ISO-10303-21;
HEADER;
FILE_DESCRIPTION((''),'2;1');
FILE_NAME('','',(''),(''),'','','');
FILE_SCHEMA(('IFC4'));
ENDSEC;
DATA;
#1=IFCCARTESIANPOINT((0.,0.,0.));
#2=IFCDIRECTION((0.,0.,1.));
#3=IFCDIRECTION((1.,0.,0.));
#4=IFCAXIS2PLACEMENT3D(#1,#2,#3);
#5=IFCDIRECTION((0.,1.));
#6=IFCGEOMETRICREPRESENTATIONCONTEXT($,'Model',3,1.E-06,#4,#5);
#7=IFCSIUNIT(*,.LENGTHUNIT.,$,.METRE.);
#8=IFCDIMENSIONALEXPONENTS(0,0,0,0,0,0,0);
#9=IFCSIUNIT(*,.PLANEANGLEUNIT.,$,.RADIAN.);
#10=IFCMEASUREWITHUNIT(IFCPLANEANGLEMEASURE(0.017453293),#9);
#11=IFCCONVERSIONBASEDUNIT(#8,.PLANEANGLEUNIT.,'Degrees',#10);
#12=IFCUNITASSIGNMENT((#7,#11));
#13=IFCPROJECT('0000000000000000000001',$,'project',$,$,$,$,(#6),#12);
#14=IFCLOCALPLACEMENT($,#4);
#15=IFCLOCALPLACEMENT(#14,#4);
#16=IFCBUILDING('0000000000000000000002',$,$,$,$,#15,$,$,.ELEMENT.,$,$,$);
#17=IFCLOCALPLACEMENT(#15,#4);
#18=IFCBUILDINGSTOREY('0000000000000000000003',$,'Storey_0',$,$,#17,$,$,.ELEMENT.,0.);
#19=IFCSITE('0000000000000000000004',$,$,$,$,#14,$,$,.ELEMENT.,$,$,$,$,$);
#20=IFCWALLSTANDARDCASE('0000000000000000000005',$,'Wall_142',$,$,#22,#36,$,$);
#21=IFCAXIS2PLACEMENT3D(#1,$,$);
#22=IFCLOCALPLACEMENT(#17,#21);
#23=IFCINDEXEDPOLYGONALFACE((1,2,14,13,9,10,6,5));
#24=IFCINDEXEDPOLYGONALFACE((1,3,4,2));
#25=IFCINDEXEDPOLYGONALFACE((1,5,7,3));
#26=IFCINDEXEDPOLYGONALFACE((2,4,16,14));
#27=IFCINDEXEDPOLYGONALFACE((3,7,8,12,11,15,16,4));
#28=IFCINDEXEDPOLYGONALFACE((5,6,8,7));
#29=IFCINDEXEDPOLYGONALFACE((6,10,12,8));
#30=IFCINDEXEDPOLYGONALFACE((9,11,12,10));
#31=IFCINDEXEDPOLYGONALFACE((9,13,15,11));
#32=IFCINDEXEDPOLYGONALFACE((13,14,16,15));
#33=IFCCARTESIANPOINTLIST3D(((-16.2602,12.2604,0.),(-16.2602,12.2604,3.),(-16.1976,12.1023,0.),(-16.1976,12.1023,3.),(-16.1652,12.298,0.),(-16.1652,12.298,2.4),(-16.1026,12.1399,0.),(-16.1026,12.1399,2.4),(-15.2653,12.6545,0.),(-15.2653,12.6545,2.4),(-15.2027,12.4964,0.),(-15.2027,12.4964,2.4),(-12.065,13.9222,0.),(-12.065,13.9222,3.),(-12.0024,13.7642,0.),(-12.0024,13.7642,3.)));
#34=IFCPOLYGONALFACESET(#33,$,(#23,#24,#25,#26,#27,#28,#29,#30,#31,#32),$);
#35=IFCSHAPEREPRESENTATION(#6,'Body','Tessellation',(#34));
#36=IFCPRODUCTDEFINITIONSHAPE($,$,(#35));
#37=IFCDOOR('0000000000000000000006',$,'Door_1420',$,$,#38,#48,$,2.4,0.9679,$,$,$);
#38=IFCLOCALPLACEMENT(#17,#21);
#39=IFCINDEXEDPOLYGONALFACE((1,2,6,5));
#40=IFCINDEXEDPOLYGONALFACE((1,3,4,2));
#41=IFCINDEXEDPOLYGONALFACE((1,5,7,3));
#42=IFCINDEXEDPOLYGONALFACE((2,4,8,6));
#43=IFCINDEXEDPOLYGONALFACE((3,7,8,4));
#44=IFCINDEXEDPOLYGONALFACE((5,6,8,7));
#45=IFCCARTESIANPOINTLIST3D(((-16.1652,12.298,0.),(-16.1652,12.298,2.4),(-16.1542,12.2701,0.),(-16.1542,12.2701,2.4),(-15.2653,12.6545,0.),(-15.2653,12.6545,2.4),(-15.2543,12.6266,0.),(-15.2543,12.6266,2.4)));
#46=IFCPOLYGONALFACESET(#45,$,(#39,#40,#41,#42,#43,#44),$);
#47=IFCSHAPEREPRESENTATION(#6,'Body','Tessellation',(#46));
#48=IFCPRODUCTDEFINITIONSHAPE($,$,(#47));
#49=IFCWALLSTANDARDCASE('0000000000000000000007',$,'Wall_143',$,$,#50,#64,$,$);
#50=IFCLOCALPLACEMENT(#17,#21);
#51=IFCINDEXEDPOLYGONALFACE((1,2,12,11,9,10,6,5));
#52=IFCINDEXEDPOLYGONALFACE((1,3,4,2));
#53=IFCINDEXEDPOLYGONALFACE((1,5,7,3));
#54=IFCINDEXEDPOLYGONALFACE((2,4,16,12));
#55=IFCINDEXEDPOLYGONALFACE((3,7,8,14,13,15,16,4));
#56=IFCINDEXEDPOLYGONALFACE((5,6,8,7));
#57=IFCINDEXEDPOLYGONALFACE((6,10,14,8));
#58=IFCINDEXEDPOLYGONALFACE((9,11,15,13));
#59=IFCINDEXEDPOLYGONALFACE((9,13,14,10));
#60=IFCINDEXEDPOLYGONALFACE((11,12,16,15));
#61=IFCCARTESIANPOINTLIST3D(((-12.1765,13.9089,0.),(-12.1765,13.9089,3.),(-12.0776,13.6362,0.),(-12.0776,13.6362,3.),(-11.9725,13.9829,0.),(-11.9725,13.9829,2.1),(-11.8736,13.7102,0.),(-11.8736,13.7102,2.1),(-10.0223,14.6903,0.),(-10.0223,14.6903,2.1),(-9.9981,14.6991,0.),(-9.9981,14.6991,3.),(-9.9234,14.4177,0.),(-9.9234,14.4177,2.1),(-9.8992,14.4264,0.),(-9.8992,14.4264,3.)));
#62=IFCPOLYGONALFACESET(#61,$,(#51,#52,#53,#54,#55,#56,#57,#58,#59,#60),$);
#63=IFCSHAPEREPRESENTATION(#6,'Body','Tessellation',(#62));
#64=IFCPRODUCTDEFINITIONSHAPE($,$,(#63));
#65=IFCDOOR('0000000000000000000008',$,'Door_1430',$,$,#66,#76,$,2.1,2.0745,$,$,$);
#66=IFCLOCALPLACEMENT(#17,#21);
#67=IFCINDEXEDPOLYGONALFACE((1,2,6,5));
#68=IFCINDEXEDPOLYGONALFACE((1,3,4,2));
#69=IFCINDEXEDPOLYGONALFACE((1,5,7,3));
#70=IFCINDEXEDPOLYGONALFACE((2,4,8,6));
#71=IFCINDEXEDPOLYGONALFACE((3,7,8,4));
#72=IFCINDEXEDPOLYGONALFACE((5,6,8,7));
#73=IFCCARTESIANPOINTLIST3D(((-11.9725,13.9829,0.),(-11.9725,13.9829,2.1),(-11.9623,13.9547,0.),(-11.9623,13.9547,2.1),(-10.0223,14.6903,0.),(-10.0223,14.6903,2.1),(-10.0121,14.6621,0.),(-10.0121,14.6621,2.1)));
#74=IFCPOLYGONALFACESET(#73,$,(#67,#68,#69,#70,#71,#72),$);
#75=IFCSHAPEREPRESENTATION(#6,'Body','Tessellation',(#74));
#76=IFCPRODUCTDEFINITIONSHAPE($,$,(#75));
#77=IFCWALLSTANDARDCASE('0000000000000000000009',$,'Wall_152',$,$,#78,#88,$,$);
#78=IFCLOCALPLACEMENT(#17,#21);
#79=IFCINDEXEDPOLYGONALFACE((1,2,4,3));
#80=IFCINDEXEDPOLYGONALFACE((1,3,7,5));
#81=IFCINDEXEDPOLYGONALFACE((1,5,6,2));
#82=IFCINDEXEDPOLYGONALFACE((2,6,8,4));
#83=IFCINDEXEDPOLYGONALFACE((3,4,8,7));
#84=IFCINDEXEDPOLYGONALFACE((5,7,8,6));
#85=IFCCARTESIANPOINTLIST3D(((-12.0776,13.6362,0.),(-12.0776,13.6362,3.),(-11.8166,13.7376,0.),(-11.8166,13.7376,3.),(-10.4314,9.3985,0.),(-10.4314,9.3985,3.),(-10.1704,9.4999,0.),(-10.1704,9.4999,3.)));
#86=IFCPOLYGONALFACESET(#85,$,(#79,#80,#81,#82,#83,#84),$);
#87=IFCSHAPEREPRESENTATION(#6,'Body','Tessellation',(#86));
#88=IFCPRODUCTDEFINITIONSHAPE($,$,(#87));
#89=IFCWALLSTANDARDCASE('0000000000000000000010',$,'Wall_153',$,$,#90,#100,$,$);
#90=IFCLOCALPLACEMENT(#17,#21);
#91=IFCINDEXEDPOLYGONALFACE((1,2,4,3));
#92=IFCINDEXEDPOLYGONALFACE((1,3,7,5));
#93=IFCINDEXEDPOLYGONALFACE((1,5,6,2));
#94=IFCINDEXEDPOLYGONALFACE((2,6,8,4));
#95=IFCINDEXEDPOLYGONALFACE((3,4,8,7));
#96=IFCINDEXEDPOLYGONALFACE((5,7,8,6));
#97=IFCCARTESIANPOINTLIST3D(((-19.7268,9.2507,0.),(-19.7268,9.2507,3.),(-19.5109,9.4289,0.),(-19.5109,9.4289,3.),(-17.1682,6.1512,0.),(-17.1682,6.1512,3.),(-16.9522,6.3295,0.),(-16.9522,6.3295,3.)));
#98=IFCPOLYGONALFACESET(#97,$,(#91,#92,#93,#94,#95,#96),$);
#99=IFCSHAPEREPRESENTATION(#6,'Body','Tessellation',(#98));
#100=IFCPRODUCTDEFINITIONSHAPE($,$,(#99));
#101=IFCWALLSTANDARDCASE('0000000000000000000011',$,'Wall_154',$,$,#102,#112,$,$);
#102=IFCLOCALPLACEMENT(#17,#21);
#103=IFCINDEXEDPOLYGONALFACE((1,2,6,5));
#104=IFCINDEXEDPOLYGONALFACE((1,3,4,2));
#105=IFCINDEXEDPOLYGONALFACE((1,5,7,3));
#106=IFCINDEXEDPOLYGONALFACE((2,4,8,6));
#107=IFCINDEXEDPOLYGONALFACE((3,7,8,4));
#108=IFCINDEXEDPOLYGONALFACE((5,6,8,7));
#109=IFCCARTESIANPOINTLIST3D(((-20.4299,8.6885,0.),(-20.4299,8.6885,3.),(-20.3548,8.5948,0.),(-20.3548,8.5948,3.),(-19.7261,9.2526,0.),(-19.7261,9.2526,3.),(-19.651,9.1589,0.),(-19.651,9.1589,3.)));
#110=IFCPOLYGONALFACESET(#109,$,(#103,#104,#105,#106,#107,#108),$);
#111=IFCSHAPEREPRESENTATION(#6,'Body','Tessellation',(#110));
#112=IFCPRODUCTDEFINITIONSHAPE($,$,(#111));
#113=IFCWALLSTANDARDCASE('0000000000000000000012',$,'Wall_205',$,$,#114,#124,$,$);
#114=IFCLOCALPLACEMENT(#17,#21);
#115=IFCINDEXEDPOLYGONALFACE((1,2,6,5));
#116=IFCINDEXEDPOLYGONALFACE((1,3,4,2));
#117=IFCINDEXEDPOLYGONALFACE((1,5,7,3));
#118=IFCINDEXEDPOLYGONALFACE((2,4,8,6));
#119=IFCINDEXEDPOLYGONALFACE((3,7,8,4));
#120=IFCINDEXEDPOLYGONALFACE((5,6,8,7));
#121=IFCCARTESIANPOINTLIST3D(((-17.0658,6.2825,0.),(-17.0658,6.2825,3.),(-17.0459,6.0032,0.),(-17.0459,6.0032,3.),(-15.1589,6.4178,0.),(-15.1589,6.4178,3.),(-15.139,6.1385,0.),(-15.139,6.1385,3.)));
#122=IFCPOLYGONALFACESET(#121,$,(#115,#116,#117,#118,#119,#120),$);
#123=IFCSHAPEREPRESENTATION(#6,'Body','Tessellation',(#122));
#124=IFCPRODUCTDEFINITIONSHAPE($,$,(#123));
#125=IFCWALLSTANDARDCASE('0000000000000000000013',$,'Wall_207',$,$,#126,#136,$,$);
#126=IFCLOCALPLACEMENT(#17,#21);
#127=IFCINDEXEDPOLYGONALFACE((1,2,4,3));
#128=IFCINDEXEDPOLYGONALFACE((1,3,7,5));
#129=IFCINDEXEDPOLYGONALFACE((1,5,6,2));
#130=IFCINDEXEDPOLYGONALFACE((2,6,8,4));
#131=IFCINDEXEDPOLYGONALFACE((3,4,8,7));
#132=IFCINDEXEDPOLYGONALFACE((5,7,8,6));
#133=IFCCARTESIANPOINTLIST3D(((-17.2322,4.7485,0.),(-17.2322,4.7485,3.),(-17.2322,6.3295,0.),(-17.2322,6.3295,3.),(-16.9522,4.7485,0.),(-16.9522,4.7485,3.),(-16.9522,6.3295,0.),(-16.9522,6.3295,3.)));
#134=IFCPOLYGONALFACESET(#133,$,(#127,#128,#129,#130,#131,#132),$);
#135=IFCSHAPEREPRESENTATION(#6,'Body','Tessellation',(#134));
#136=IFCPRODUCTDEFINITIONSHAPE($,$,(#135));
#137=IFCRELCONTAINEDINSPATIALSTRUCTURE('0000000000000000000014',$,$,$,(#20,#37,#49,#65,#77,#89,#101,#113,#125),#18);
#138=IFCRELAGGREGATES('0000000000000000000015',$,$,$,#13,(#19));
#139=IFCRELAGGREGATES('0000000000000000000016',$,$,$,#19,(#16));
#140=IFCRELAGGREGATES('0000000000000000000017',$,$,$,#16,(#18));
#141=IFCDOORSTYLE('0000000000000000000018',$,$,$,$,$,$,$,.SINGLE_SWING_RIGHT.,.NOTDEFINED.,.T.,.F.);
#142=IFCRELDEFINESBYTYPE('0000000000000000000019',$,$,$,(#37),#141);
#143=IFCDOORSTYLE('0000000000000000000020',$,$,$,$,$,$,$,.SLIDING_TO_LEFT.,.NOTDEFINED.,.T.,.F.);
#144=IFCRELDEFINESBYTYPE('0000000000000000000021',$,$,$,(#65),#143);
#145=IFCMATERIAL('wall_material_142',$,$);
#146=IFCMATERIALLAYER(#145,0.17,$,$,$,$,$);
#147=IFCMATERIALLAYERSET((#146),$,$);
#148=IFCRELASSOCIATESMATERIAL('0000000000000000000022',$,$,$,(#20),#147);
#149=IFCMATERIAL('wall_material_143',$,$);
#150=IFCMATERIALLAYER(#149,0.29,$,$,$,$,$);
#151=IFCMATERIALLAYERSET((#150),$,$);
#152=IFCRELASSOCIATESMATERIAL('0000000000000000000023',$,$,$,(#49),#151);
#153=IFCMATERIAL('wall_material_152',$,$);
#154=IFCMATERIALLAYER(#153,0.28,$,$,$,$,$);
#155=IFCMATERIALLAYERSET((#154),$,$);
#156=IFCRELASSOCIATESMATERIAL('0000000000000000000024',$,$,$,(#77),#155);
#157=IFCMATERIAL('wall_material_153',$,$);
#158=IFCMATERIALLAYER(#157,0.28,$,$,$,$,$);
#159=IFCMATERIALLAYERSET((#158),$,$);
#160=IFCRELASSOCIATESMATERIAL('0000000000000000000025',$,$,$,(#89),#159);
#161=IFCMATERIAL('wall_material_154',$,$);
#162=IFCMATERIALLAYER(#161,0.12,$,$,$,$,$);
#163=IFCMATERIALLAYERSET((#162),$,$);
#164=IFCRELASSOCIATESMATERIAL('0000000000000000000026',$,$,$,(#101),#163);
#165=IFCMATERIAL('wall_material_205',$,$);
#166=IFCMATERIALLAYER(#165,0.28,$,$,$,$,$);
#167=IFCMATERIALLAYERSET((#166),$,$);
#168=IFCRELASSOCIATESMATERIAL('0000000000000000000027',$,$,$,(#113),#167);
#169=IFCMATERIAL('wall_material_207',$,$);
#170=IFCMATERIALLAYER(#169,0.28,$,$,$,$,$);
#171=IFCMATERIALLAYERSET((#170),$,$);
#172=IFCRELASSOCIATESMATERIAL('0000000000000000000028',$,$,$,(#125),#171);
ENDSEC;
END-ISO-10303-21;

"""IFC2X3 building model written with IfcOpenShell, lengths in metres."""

from ifc_helpers import new_model, entity, si_unit, converted_unit, direction, frame, frame_2d, origin_with_axes, place, context, project, spatial, polyline, rectangle, outline, extrude, material, layer, layer_set, layer_usage, type_object, element, fill, save


model = new_model("IFC2X3")

# Units and contexts
model_context = context("Model", 3, precision=1e-06, world=origin_with_axes(), true_north=direction((0.0, 1.0)))
ifc_project = project(units=[si_unit("LENGTHUNIT", "METRE"), converted_unit("PLANEANGLEUNIT", "Degrees", entity("IfcPlaneAngleMeasure", 0.017453293), si_unit("PLANEANGLEUNIT", "RADIAN"), dimensions=[0, 0, 0, 0, 0, 0, 0])], contexts=[model_context])

# Site, building, storey
site_placement = place(None, origin_with_axes())
site = spatial("IfcSite", under=ifc_project, at=site_placement, CompositionType="ELEMENT")
building_placement = place(site_placement, origin_with_axes())
building = spatial("IfcBuilding", under=site, at=building_placement, CompositionType="ELEMENT")
storey_placement = place(building_placement, origin_with_axes())
storey = spatial("IfcBuildingStorey", under=building, at=storey_placement, Name="Storey_0", CompositionType="ELEMENT", Elevation=0.0)

# Walls, openings, doors
ifc_material_1 = material(Name="wall_material_142")
ifc_layer_1 = layer(ifc_material_1, 0.17)
ifc_layer_set_1 = layer_set([ifc_layer_1])
ifc_layer_usage_1 = layer_usage(ifc_layer_set_1, "AXIS2", "NEGATIVE", 0.0)
wall_1_placement = place(storey_placement, frame((-16.2602, 12.2604, 0.0), z_axis=(0.0, 0.0, 1.0), x_axis=(0.929712, 0.368287, 0.0)))
wall_1 = element("IfcWallStandardCase", 1, at=wall_1_placement, inside=storey, material=ifc_layer_usage_1, Name="Wall_142", context=model_context, shape_type="SweptSolid", body=[
    extrude(outline(polyline([(0.0, 0.0), (4.5124, 0.0), (4.5124, -0.17), (0.0, -0.17), (0.0, 0.0)])), origin_with_axes(), (0.0, 0.0, 1.0), 3.0),
])
opening_1_placement = place(wall_1_placement, frame((0.1021, 0.0, 0.0), z_axis=(0.0, 0.0, 1.0), x_axis=(1.0, 0.0, 0.0)))
opening_1 = element("IfcOpeningElement", 2, at=opening_1_placement, cuts=wall_1, context=model_context, shape_type="SweptSolid", body=[
    extrude(rectangle(XDim=0.9679, YDim=2.4, at=frame_2d((1.2, -0.4839), x_axis=(0.0, 1.0))), frame((0.0, 0.01, 0.0), z_axis=(0.0, -1.0, 0.0), x_axis=(0.0, 0.0, 1.0)), (0.0, 0.0, 1.0), 0.19),
])
door_style_1 = type_object("IfcDoorStyle", ConstructionType="NOTDEFINED", OperationType="SINGLE_SWING_RIGHT", ParameterTakesPrecedence=True, Sizeable=False)
door_1_placement = place(storey_placement, origin_with_axes())
door_1 = element("IfcDoor", 3, at=door_1_placement, inside=storey, type_object=door_style_1, Name="Door_1420", OverallHeight=2.4, OverallWidth=0.9679, context=model_context, shape_type="SweptSolid", body=[
    extrude(outline(polyline([(-16.1652, 12.298), (-15.2653, 12.6545), (-15.2543, 12.6266), (-16.1542, 12.2701), (-16.1652, 12.298)])), origin_with_axes(), (0.0, 0.0, 1.0), 2.4),
])
fill(opening_1, door_1)
ifc_material_2 = material(Name="wall_material_143")
ifc_layer_2 = layer(ifc_material_2, 0.29)
ifc_layer_set_2 = layer_set([ifc_layer_2])
ifc_layer_usage_2 = layer_usage(ifc_layer_set_2, "AXIS2", "NEGATIVE", 0.0)
wall_2_placement = place(storey_placement, frame((-12.1765, 13.9089, 0.0), z_axis=(0.0, 0.0, 1.0), x_axis=(0.940062, 0.341004, 0.0)))
wall_2 = element("IfcWallStandardCase", 4, at=wall_2_placement, inside=storey, material=ifc_layer_usage_2, Name="Wall_143", context=model_context, shape_type="SweptSolid", body=[
    extrude(outline(polyline([(0.0, 0.0), (2.3173, 0.0), (2.3173, -0.29), (0.0, -0.29), (0.0, 0.0)])), origin_with_axes(), (0.0, 0.0, 1.0), 3.0),
])
opening_2_placement = place(wall_2_placement, frame((0.217, 0.0, 0.0), z_axis=(0.0, 0.0, 1.0), x_axis=(1.0, 0.0, 0.0)))
opening_2 = element("IfcOpeningElement", 5, at=opening_2_placement, cuts=wall_2, context=model_context, shape_type="SweptSolid", body=[
    extrude(rectangle(XDim=2.0745, YDim=2.1, at=frame_2d((1.05, -1.0373), x_axis=(0.0, 1.0))), frame((0.0, 0.01, 0.0), z_axis=(0.0, -1.0, 0.0), x_axis=(0.0, 0.0, 1.0)), (0.0, 0.0, 1.0), 0.31),
])
door_style_2 = type_object("IfcDoorStyle", ConstructionType="NOTDEFINED", OperationType="SLIDING_TO_LEFT", ParameterTakesPrecedence=True, Sizeable=False)
door_2_placement = place(storey_placement, origin_with_axes())
door_2 = element("IfcDoor", 6, at=door_2_placement, inside=storey, type_object=door_style_2, Name="Door_1430", OverallHeight=2.1, OverallWidth=2.0745, context=model_context, shape_type="SweptSolid", body=[
    extrude(outline(polyline([(-11.9725, 13.9829), (-10.0223, 14.6903), (-10.0121, 14.6621), (-11.9623, 13.9547), (-11.9725, 13.9829)])), origin_with_axes(), (0.0, 0.0, 1.0), 2.1),
])
fill(opening_2, door_2)

# Walls
ifc_material_3 = material(Name="wall_material_152")
ifc_layer_3 = layer(ifc_material_3, 0.28)
ifc_layer_set_3 = layer_set([ifc_layer_3])
ifc_layer_usage_3 = layer_usage(ifc_layer_set_3, "AXIS2", "POSITIVE", 0.0)
wall_3_placement = place(storey_placement, frame((-12.0776, 13.6362, 0.0), z_axis=(0.0, 0.0, 1.0), x_axis=(0.362113, -0.932134, 0.0)))
element("IfcWallStandardCase", 7, at=wall_3_placement, inside=storey, material=ifc_layer_usage_3, Name="Wall_152", context=model_context, shape_type="SweptSolid", body=[
    extrude(outline(polyline([(0.0, 0.28), (4.5462, 0.28), (4.5462, 0.0), (0.0, 0.0), (0.0, 0.28)])), origin_with_axes(), (0.0, 0.0, 1.0), 3.0),
])
ifc_material_4 = material(Name="wall_material_153")
ifc_layer_4 = layer(ifc_material_4, 0.28)
ifc_layer_set_4 = layer_set([ifc_layer_4])
ifc_layer_usage_4 = layer_usage(ifc_layer_set_4, "AXIS2", "POSITIVE", 0.0)
wall_4_placement = place(storey_placement, frame((-16.9522, 6.3295, 0.0), z_axis=(0.0, 0.0, 1.0), x_axis=(-0.636617, 0.77118, 0.0)))
element("IfcWallStandardCase", 8, at=wall_4_placement, inside=storey, material=ifc_layer_usage_4, Name="Wall_153", context=model_context, shape_type="SweptSolid", body=[
    extrude(outline(polyline([(0.0, 0.28), (4.0191, 0.28), (4.0191, 0.0), (0.0, 0.0), (0.0, 0.28)])), origin_with_axes(), (0.0, 0.0, 1.0), 3.0),
])
ifc_material_5 = material(Name="wall_material_154")
ifc_layer_5 = layer(ifc_material_5, 0.12)
ifc_layer_set_5 = layer_set([ifc_layer_5])
ifc_layer_usage_5 = layer_usage(ifc_layer_set_5, "AXIS2", "POSITIVE", 0.0)
wall_5_placement = place(storey_placement, frame((-20.3548, 8.5948, 0.0), z_axis=(0.0, 0.0, 1.0), x_axis=(0.780297, 0.625409, 0.0)))
element("IfcWallStandardCase", 9, at=wall_5_placement, inside=storey, material=ifc_layer_usage_5, Name="Wall_154", context=model_context, shape_type="SweptSolid", body=[
    extrude(outline(polyline([(0.0, 0.12), (0.9019, 0.12), (0.9019, 0.0), (0.0, 0.0), (0.0, 0.12)])), origin_with_axes(), (0.0, 0.0, 1.0), 3.0),
])
ifc_material_6 = material(Name="wall_material_205")
ifc_layer_6 = layer(ifc_material_6, 0.28)
ifc_layer_set_6 = layer_set([ifc_layer_6])
ifc_layer_usage_6 = layer_usage(ifc_layer_set_6, "AXIS2", "NEGATIVE", 0.0)
wall_6_placement = place(storey_placement, frame((-15.139, 6.1385, 0.0), z_axis=(0.0, 0.0, 1.0), x_axis=(-0.99749, -0.070801, 0.0)))
element("IfcWallStandardCase", 10, at=wall_6_placement, inside=storey, material=ifc_layer_usage_6, Name="Wall_205", context=model_context, shape_type="SweptSolid", body=[
    extrude(outline(polyline([(0.0, 0.0), (1.9117, 0.0), (1.9117, -0.28), (0.0, -0.28), (0.0, 0.0)])), origin_with_axes(), (0.0, 0.0, 1.0), 3.0),
])
ifc_material_7 = material(Name="wall_material_207")
ifc_layer_7 = layer(ifc_material_7, 0.28)
ifc_layer_set_7 = layer_set([ifc_layer_7])
ifc_layer_usage_7 = layer_usage(ifc_layer_set_7, "AXIS2", "NEGATIVE", 0.0)
wall_7_placement = place(storey_placement, frame((-16.9522, 6.3295, 0.0), z_axis=(0.0, 0.0, 1.0), x_axis=(0.0, -1.0, 0.0)))
element("IfcWallStandardCase", 11, at=wall_7_placement, inside=storey, material=ifc_layer_usage_7, Name="Wall_207", context=model_context, shape_type="SweptSolid", body=[
    extrude(outline(polyline([(0.0, 0.0), (1.581, 0.0), (1.581, -0.28), (0.0, -0.28), (0.0, 0.0)])), origin_with_axes(), (0.0, 0.0, 1.0), 3.0),
])

save(model, "model.ifc")
